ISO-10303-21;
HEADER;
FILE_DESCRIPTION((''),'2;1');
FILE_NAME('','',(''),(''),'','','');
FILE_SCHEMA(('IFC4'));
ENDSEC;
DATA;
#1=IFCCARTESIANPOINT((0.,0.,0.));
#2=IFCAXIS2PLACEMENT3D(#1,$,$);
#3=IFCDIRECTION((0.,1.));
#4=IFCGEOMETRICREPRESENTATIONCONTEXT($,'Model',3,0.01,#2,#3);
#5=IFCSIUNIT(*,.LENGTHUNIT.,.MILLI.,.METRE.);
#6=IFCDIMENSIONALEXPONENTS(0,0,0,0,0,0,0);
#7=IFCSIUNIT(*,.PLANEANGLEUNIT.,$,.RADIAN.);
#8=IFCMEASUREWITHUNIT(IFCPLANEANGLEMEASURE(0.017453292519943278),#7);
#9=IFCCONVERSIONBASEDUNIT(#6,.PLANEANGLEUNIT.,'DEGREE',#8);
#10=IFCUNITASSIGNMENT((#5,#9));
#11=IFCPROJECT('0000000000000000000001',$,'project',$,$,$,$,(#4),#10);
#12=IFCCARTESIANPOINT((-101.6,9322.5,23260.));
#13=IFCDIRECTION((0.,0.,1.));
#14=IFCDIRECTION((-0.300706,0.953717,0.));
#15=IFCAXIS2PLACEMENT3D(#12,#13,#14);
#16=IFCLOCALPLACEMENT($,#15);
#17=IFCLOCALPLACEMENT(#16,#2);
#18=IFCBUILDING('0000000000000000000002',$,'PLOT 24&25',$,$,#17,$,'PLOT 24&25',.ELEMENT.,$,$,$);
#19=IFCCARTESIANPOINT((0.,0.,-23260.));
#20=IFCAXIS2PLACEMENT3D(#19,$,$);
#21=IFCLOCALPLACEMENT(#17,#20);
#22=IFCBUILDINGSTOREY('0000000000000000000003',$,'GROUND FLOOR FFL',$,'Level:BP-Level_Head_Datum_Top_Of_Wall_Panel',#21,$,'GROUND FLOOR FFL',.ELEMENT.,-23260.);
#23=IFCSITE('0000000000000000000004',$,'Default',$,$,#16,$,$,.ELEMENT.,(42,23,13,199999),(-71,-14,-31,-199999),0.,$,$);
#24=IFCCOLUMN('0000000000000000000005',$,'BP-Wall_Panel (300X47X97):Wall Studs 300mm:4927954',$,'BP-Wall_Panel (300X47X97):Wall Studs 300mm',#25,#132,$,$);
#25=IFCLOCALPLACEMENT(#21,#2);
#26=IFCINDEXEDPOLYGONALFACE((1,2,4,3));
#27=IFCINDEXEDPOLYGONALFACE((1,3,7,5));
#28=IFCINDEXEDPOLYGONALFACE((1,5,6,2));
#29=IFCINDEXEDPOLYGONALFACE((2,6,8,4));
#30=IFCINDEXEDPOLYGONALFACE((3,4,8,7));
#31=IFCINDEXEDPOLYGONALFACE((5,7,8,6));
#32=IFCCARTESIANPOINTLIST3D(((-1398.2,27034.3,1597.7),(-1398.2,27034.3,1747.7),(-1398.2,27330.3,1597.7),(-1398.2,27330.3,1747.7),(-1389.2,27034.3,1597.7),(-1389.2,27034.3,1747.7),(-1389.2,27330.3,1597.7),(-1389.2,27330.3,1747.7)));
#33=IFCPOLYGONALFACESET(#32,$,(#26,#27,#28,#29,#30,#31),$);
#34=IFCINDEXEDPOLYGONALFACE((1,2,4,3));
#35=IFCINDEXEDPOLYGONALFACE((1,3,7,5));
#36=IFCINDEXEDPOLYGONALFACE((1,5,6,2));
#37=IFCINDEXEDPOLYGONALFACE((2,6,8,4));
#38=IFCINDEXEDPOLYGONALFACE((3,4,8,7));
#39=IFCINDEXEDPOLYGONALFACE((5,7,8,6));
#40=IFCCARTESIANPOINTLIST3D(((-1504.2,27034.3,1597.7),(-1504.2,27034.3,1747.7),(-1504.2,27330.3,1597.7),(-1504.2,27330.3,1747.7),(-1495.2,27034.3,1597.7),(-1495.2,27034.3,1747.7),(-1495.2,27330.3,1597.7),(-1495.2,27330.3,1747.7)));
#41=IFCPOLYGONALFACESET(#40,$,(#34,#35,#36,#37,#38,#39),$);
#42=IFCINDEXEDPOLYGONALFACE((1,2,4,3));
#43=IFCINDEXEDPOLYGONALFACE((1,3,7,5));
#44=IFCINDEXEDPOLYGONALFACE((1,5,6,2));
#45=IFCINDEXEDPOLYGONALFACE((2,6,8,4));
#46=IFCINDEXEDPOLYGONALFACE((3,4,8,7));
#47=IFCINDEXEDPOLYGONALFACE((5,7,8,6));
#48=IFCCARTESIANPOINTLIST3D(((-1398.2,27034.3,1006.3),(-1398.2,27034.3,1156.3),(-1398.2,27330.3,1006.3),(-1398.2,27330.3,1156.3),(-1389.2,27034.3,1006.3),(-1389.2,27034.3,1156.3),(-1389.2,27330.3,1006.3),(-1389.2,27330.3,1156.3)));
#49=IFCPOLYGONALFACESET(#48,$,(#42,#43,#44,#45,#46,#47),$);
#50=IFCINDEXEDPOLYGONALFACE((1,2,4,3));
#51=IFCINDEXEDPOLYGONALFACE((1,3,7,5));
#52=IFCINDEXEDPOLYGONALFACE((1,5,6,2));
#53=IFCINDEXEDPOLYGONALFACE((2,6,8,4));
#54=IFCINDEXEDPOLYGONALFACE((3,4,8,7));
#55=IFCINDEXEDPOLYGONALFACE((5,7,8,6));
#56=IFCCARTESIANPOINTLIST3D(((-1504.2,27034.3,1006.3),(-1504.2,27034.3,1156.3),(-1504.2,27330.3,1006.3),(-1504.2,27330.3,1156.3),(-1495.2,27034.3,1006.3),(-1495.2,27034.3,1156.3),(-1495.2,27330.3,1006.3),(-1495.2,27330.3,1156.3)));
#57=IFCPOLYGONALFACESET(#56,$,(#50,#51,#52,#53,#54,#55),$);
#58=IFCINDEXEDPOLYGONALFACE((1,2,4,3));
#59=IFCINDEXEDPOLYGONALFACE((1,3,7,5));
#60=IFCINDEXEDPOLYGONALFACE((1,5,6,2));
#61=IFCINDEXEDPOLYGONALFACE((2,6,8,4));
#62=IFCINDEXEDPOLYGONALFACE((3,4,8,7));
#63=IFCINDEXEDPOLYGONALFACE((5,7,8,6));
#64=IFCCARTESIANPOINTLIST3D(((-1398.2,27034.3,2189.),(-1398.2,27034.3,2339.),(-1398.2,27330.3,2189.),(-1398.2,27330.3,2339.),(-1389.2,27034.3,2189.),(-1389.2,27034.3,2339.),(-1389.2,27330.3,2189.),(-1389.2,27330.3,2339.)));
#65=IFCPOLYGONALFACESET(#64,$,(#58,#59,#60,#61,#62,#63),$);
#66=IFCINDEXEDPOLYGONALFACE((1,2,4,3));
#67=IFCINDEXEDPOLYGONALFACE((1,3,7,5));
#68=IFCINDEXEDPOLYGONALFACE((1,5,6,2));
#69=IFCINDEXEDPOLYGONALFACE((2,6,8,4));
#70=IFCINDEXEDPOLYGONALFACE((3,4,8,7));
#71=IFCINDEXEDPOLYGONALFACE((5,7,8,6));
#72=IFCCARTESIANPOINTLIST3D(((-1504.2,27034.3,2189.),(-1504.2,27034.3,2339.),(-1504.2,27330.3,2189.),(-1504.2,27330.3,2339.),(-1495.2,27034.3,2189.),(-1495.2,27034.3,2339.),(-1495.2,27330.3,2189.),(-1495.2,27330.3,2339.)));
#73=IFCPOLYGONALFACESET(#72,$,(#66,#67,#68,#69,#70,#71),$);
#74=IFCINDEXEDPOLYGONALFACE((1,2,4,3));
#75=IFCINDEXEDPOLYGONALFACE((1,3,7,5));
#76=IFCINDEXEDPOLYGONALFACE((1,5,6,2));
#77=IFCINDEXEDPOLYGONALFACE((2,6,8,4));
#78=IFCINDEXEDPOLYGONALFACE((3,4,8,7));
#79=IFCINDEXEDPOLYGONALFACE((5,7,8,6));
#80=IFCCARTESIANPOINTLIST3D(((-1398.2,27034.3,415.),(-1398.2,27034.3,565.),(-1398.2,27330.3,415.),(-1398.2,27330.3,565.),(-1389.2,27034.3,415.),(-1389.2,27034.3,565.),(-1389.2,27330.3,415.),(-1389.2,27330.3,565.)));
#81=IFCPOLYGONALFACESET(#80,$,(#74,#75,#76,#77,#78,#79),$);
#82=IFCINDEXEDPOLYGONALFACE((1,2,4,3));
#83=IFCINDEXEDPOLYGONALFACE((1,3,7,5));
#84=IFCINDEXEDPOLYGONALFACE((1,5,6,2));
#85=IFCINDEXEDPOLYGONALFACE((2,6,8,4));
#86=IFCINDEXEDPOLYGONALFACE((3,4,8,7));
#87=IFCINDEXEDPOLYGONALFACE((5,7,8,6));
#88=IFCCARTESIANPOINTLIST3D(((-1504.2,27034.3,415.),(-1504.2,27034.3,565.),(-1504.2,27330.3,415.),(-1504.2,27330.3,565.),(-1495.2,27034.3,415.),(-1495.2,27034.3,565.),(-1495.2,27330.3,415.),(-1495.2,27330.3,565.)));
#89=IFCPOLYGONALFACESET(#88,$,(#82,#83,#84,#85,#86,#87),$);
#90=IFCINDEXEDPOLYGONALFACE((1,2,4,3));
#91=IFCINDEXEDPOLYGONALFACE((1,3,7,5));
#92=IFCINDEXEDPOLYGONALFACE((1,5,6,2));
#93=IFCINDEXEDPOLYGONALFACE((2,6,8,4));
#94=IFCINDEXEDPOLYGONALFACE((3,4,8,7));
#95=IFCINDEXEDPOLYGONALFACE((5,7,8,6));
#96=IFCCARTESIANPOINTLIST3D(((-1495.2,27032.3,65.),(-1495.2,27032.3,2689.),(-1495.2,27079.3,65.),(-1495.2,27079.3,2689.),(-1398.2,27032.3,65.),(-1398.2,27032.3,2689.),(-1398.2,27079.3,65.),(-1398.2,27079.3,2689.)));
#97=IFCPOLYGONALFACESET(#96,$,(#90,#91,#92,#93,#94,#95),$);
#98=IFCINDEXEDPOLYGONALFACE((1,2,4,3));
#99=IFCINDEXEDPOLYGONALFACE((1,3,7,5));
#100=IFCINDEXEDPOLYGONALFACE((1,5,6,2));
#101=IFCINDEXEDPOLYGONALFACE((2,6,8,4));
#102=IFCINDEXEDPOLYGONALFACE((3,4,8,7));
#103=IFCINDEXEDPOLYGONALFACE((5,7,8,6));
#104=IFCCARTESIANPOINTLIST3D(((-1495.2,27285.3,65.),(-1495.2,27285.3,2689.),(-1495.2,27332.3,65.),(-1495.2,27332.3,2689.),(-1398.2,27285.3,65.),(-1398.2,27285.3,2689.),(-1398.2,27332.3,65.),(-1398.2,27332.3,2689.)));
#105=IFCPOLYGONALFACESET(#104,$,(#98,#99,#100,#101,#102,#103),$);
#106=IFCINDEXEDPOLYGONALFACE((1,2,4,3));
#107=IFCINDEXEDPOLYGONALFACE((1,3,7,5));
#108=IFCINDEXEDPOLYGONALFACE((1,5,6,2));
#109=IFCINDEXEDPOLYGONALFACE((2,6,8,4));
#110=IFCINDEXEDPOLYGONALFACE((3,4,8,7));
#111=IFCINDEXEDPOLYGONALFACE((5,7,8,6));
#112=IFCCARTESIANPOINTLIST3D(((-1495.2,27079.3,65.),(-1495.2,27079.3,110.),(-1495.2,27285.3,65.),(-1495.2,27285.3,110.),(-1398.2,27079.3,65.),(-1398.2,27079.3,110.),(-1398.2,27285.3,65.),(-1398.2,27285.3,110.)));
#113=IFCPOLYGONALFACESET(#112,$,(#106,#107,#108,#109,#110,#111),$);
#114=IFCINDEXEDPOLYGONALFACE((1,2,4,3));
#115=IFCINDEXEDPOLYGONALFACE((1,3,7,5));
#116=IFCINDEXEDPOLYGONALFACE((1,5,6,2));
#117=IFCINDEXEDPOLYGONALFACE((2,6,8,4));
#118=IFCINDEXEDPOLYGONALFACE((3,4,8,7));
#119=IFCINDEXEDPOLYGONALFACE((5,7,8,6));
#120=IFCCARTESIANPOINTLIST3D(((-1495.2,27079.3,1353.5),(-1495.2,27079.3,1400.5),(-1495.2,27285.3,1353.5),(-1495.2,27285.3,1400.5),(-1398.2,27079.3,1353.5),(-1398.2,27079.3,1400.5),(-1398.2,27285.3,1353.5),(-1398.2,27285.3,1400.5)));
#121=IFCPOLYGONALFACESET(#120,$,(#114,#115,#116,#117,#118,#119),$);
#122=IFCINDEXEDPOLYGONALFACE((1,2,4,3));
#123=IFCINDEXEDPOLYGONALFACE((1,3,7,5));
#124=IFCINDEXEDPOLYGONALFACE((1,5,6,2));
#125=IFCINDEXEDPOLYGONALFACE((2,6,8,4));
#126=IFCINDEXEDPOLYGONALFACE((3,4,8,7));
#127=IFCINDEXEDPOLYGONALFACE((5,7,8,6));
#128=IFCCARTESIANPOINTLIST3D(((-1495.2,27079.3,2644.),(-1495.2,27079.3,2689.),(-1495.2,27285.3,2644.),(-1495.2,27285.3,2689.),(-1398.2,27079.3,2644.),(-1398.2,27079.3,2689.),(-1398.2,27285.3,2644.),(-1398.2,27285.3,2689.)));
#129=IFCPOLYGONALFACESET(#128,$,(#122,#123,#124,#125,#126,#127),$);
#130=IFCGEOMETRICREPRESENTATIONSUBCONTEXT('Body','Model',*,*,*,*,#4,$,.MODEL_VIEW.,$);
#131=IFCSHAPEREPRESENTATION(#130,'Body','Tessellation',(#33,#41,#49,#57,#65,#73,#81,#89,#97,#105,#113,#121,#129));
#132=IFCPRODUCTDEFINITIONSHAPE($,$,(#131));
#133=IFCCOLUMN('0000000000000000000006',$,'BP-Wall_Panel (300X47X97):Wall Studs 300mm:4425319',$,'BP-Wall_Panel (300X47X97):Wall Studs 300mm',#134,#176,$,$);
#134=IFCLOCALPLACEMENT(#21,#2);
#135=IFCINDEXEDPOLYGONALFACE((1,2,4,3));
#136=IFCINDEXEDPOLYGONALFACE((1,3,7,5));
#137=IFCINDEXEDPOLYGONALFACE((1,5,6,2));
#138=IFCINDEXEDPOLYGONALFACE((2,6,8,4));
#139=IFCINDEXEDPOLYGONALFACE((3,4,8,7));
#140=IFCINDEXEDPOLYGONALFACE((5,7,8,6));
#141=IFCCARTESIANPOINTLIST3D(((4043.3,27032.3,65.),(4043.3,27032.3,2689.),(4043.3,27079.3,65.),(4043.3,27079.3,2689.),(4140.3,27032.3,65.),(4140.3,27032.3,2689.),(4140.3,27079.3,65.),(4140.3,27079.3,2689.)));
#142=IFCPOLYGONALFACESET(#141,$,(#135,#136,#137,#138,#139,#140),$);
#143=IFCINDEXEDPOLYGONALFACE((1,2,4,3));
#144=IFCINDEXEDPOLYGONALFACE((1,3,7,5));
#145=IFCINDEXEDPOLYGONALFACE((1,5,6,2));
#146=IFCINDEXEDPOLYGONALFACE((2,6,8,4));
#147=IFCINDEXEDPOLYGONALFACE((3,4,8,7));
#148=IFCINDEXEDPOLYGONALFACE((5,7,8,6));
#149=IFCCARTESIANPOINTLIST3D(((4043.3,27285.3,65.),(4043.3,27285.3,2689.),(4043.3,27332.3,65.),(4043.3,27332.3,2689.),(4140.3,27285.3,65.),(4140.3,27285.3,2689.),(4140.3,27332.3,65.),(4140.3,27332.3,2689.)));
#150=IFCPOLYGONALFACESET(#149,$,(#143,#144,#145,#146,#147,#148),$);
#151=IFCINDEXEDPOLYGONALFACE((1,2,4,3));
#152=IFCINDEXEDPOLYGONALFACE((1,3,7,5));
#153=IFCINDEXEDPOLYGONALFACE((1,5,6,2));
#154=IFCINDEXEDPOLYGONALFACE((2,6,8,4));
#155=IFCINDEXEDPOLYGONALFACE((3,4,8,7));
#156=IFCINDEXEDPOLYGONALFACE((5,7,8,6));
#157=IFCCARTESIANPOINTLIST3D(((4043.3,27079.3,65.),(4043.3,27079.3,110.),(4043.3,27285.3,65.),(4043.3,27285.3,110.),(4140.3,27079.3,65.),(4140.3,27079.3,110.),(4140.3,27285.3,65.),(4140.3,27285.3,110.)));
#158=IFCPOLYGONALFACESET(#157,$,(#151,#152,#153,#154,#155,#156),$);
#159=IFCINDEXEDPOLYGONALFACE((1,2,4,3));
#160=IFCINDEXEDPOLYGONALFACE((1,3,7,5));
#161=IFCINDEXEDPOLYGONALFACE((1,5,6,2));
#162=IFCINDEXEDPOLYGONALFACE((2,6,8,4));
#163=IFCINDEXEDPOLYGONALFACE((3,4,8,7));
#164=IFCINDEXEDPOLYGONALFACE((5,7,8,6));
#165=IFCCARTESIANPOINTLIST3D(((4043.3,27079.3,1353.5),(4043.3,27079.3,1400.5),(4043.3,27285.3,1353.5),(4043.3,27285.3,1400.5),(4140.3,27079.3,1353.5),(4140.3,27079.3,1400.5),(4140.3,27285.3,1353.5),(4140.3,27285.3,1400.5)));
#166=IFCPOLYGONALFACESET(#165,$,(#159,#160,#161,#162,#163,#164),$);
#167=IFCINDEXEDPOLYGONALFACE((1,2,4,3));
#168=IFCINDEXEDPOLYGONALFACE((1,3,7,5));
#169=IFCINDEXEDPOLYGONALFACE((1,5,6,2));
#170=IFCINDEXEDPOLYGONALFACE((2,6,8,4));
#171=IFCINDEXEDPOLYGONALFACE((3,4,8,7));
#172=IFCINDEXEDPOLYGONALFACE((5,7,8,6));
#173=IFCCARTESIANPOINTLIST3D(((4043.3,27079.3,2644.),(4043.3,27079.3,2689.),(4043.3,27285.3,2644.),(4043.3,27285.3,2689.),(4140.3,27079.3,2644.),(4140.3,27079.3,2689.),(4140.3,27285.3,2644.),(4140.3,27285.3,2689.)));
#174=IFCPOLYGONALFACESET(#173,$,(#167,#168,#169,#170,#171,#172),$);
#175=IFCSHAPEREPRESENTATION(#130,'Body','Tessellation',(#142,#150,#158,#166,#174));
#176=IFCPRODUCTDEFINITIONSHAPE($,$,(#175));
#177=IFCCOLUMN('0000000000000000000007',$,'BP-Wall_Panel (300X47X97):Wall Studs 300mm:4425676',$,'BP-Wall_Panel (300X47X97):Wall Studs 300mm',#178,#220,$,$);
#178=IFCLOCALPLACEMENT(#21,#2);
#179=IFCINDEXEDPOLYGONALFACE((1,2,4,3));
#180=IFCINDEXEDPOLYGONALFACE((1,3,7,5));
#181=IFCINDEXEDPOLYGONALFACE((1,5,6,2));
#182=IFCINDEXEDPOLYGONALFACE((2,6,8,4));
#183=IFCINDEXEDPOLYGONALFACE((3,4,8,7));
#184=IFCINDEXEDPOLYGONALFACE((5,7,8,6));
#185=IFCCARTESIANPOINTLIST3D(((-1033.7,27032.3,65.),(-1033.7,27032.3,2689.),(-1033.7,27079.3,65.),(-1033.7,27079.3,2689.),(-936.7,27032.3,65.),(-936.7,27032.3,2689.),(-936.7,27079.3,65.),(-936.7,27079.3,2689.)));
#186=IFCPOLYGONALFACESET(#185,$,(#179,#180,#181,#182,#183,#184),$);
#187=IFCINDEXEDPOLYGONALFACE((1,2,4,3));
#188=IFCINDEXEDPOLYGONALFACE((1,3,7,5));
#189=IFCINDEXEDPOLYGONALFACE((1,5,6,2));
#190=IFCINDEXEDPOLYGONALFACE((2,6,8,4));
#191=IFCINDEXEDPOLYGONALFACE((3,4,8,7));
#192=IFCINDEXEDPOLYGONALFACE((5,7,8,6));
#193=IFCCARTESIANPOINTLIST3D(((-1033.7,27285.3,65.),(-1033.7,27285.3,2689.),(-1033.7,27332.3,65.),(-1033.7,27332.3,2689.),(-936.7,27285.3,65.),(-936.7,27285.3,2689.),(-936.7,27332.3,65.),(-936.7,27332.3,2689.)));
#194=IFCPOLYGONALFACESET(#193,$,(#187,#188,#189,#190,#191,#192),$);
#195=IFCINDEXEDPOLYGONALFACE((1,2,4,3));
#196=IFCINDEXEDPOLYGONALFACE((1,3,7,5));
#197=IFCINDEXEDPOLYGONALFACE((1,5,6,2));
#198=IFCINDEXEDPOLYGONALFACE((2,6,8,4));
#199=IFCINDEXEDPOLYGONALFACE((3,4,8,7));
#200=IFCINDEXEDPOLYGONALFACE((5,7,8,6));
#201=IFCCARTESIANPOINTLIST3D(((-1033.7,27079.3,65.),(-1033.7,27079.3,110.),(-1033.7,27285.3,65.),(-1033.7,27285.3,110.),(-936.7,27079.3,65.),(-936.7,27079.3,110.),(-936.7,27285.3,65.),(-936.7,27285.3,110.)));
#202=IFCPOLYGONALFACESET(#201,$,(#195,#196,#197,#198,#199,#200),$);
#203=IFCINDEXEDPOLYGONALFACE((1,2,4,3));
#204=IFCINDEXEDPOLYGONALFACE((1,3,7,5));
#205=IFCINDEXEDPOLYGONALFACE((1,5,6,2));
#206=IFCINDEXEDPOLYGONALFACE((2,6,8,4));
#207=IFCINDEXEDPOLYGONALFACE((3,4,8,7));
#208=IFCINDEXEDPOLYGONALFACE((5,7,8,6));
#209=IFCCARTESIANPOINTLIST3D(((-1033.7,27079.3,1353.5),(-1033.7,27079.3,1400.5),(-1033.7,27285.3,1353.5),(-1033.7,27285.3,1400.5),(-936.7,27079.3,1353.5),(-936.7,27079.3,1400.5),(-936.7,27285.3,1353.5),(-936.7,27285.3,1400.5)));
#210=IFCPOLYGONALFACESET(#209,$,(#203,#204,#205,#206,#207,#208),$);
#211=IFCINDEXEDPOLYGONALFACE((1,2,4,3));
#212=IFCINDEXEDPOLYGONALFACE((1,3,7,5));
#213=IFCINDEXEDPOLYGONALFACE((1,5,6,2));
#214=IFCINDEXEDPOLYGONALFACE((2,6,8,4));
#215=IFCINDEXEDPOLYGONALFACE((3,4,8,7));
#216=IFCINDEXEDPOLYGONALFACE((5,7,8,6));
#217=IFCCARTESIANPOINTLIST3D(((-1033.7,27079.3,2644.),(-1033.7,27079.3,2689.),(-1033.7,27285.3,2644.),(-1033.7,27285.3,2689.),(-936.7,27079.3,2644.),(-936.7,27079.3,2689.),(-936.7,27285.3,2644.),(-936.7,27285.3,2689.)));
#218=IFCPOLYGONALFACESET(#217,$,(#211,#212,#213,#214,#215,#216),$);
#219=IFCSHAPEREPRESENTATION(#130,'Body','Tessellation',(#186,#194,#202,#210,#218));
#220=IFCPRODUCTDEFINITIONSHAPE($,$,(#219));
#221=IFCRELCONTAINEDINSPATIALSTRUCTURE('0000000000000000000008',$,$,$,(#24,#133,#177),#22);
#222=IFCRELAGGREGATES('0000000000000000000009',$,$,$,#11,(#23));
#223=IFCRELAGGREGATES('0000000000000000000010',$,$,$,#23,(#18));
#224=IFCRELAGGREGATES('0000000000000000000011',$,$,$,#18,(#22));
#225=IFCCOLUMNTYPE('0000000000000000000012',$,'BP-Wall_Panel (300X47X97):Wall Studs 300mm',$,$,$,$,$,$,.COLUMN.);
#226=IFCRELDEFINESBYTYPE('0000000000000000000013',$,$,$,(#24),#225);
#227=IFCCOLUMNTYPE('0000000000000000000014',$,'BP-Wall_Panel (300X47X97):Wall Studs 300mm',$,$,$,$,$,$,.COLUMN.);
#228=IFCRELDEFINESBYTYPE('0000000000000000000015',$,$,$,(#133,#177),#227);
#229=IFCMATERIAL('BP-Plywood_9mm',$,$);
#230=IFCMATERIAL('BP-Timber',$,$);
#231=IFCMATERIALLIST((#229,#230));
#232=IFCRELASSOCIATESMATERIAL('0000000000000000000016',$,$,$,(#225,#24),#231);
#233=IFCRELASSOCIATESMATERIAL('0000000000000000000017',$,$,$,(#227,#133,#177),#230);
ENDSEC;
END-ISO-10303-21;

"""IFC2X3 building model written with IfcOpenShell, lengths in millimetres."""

from ifc_helpers import new_model, entity, si_unit, converted_unit, direction, frame, frame_2d, origin, origin_2d_with_axis, place, context, subcontext, project, spatial, rectangle, extrude, source, transform, mapped, material, material_list, type_object, type_shapes, element, save


model = new_model("IFC2X3")

# Units and contexts
model_context = context("Model", 3, precision=0.01, world=origin(), true_north=direction((0.0, 1.0)))
body_context = subcontext(model_context, "Body", "Model", "MODEL_VIEW")
ifc_project = project(units=[si_unit("LENGTHUNIT", "METRE", prefix="MILLI"), converted_unit("PLANEANGLEUNIT", "DEGREE", entity("IfcPlaneAngleMeasure", 0.017453292519943278), si_unit("PLANEANGLEUNIT", "RADIAN"), dimensions=[0, 0, 0, 0, 0, 0, 0])], contexts=[model_context])

# Site, building, storey
site_placement = place(None, frame((-101.6, 9322.5, 23260.0), z_axis=(0.0, 0.0, 1.0), x_axis=(-0.300706, 0.953717, 0.0)))
site = spatial("IfcSite", under=ifc_project, at=site_placement, Name="Default", CompositionType="ELEMENT", RefLatitude=(42, 23, 13, 199999), RefLongitude=(-71, -14, -31, -199999), RefElevation=0.0)
building_placement = place(site_placement, origin())
building = spatial("IfcBuilding", under=site, at=building_placement, Name="PLOT 24&25", LongName="PLOT 24&25", CompositionType="ELEMENT")
storey_placement = place(building_placement, frame((0.0, 0.0, -23260.0)))
storey = spatial("IfcBuildingStorey", under=building, at=storey_placement, Name="GROUND FLOOR FFL", ObjectType="Level:BP-Level_Head_Datum_Top_Of_Wall_Panel", LongName="GROUND FLOOR FFL", CompositionType="ELEMENT", Elevation=-23260.0)

# Columns
ifc_material_1 = material(Name="BP-Plywood_9mm")
ifc_material_2 = material(Name="BP-Timber")
ifc_material_list = material_list([ifc_material_1, ifc_material_2])
column_type_1 = type_object("IfcColumnType", Name="BP-Wall_Panel (300X47X97):Wall Studs 300mm", PredefinedType="COLUMN", material=ifc_material_list)
shared_shape_1 = source(origin(), body_context, "Body", "SweptSolid", [
    extrude(rectangle(XDim=296.0, YDim=9.0, at=origin_2d_with_axis()), frame((53.0, 0.0, -21662.3), z_axis=(0.0, 0.0, 1.0), x_axis=(0.0, -1.0, 0.0)), (0.0, 0.0, 1.0), 150.0),
    extrude(rectangle(XDim=9.0, YDim=296.0, at=origin_2d_with_axis()), frame((-53.0, 0.0, -21662.3), z_axis=(0.0, 0.0, 1.0), x_axis=(-1.0, 0.0, 0.0)), (0.0, 0.0, 1.0), 150.0),
    extrude(rectangle(XDim=296.0, YDim=9.0, at=origin_2d_with_axis()), frame((53.0, 0.0, -22253.7), z_axis=(0.0, 0.0, 1.0), x_axis=(0.0, -1.0, 0.0)), (0.0, 0.0, 1.0), 150.0),
    extrude(rectangle(XDim=9.0, YDim=296.0, at=origin_2d_with_axis()), frame((-53.0, 0.0, -22253.7), z_axis=(0.0, 0.0, 1.0), x_axis=(-1.0, 0.0, 0.0)), (0.0, 0.0, 1.0), 150.0),
    extrude(rectangle(XDim=296.0, YDim=9.0, at=origin_2d_with_axis()), frame((53.0, 0.0, -21071.0), z_axis=(0.0, 0.0, 1.0), x_axis=(0.0, -1.0, 0.0)), (0.0, 0.0, 1.0), 150.0),
    extrude(rectangle(XDim=9.0, YDim=296.0, at=origin_2d_with_axis()), frame((-53.0, 0.0, -21071.0), z_axis=(0.0, 0.0, 1.0), x_axis=(-1.0, 0.0, 0.0)), (0.0, 0.0, 1.0), 150.0),
    extrude(rectangle(XDim=296.0, YDim=9.0, at=origin_2d_with_axis()), frame((53.0, 0.0, -22845.0), z_axis=(0.0, 0.0, 1.0), x_axis=(0.0, -1.0, 0.0)), (0.0, 0.0, 1.0), 150.0),
    extrude(rectangle(XDim=9.0, YDim=296.0, at=origin_2d_with_axis()), frame((-53.0, 0.0, -22845.0), z_axis=(0.0, 0.0, 1.0), x_axis=(-1.0, 0.0, 0.0)), (0.0, 0.0, 1.0), 150.0),
    extrude(rectangle(XDim=97.0, YDim=47.0, at=origin_2d_with_axis()), frame((0.0, -126.5, -23195.0), z_axis=(0.0, 0.0, 1.0), x_axis=(-1.0, 0.0, 0.0)), (0.0, 0.0, 1.0), 2624.0),
    extrude(rectangle(XDim=97.0, YDim=47.0, at=frame_2d((0.0, 0.0), x_axis=(1.0, 0.0))), frame((0.0, 126.5, -23195.0), z_axis=(0.0, 0.0, 1.0), x_axis=(-1.0, 0.0, 0.0)), (0.0, 0.0, 1.0), 2624.0),
    extrude(rectangle(XDim=206.0, YDim=97.0, at=origin_2d_with_axis()), frame((0.0, 0.0, -23195.0), z_axis=(0.0, 0.0, 1.0), x_axis=(0.0, -1.0, 0.0)), (0.0, 0.0, 1.0), 45.0),
    extrude(rectangle(XDim=206.0, YDim=97.0, at=origin_2d_with_axis()), frame((0.0, 0.0, -21906.5), z_axis=(0.0, 0.0, 1.0), x_axis=(0.0, -1.0, 0.0)), (0.0, 0.0, 1.0), 47.0),
    extrude(rectangle(XDim=206.0, YDim=97.0, at=origin_2d_with_axis()), frame((0.0, 0.0, -20616.0), z_axis=(0.0, 0.0, 1.0), x_axis=(0.0, -1.0, 0.0)), (0.0, 0.0, 1.0), 45.0),
])
type_shapes(column_type_1, [shared_shape_1])
for number, where, name in (
    (1, (-1446.7, 27182.3, 23260.0), "BP-Wall_Panel (300X47X97):Wall Studs 300mm:4927954"),
):
    element("IfcColumn", number, at=place(storey_placement, frame(where)), inside=storey, type_object=column_type_1, material=ifc_material_list, Name=name, ObjectType="BP-Wall_Panel (300X47X97):Wall Studs 300mm", context=body_context, shape_type="MappedRepresentation", body=[
        mapped(shared_shape_1, transform((0.0, 0.0, 0.0), scale=1.0)),
    ])
column_type_2 = type_object("IfcColumnType", Name="BP-Wall_Panel (300X47X97):Wall Studs 300mm", PredefinedType="COLUMN", material=ifc_material_2)
shared_shape_2 = source(origin(), body_context, "Body", "SweptSolid", [
    extrude(rectangle(XDim=97.0, YDim=47.0, at=origin_2d_with_axis()), frame((0.0, -126.5, -23195.0), z_axis=(0.0, 0.0, 1.0), x_axis=(-1.0, 0.0, 0.0)), (0.0, 0.0, 1.0), 2624.0),
    extrude(rectangle(XDim=97.0, YDim=47.0, at=frame_2d((0.0, 0.0), x_axis=(1.0, 0.0))), frame((0.0, 126.5, -23195.0), z_axis=(0.0, 0.0, 1.0), x_axis=(-1.0, 0.0, 0.0)), (0.0, 0.0, 1.0), 2624.0),
    extrude(rectangle(XDim=206.0, YDim=97.0, at=origin_2d_with_axis()), frame((0.0, 0.0, -23195.0), z_axis=(0.0, 0.0, 1.0), x_axis=(0.0, -1.0, 0.0)), (0.0, 0.0, 1.0), 45.0),
    extrude(rectangle(XDim=206.0, YDim=97.0, at=origin_2d_with_axis()), frame((0.0, 0.0, -21906.5), z_axis=(0.0, 0.0, 1.0), x_axis=(0.0, -1.0, 0.0)), (0.0, 0.0, 1.0), 47.0),
    extrude(rectangle(XDim=206.0, YDim=97.0, at=origin_2d_with_axis()), frame((0.0, 0.0, -20616.0), z_axis=(0.0, 0.0, 1.0), x_axis=(0.0, -1.0, 0.0)), (0.0, 0.0, 1.0), 45.0),
])
type_shapes(column_type_2, [shared_shape_2])
for number, where, name in (
    (2, (4091.8, 27182.3, 23260.0), "BP-Wall_Panel (300X47X97):Wall Studs 300mm:4425319"),
    (3, (-985.2, 27182.3, 23260.0), "BP-Wall_Panel (300X47X97):Wall Studs 300mm:4425676"),
):
    element("IfcColumn", number, at=place(storey_placement, frame(where)), inside=storey, type_object=column_type_2, material=ifc_material_2, Name=name, ObjectType="BP-Wall_Panel (300X47X97):Wall Studs 300mm", context=body_context, shape_type="MappedRepresentation", body=[
        mapped(shared_shape_2, transform((0.0, 0.0, 0.0), scale=1.0)),
    ])

save(model, "model.ifc")
